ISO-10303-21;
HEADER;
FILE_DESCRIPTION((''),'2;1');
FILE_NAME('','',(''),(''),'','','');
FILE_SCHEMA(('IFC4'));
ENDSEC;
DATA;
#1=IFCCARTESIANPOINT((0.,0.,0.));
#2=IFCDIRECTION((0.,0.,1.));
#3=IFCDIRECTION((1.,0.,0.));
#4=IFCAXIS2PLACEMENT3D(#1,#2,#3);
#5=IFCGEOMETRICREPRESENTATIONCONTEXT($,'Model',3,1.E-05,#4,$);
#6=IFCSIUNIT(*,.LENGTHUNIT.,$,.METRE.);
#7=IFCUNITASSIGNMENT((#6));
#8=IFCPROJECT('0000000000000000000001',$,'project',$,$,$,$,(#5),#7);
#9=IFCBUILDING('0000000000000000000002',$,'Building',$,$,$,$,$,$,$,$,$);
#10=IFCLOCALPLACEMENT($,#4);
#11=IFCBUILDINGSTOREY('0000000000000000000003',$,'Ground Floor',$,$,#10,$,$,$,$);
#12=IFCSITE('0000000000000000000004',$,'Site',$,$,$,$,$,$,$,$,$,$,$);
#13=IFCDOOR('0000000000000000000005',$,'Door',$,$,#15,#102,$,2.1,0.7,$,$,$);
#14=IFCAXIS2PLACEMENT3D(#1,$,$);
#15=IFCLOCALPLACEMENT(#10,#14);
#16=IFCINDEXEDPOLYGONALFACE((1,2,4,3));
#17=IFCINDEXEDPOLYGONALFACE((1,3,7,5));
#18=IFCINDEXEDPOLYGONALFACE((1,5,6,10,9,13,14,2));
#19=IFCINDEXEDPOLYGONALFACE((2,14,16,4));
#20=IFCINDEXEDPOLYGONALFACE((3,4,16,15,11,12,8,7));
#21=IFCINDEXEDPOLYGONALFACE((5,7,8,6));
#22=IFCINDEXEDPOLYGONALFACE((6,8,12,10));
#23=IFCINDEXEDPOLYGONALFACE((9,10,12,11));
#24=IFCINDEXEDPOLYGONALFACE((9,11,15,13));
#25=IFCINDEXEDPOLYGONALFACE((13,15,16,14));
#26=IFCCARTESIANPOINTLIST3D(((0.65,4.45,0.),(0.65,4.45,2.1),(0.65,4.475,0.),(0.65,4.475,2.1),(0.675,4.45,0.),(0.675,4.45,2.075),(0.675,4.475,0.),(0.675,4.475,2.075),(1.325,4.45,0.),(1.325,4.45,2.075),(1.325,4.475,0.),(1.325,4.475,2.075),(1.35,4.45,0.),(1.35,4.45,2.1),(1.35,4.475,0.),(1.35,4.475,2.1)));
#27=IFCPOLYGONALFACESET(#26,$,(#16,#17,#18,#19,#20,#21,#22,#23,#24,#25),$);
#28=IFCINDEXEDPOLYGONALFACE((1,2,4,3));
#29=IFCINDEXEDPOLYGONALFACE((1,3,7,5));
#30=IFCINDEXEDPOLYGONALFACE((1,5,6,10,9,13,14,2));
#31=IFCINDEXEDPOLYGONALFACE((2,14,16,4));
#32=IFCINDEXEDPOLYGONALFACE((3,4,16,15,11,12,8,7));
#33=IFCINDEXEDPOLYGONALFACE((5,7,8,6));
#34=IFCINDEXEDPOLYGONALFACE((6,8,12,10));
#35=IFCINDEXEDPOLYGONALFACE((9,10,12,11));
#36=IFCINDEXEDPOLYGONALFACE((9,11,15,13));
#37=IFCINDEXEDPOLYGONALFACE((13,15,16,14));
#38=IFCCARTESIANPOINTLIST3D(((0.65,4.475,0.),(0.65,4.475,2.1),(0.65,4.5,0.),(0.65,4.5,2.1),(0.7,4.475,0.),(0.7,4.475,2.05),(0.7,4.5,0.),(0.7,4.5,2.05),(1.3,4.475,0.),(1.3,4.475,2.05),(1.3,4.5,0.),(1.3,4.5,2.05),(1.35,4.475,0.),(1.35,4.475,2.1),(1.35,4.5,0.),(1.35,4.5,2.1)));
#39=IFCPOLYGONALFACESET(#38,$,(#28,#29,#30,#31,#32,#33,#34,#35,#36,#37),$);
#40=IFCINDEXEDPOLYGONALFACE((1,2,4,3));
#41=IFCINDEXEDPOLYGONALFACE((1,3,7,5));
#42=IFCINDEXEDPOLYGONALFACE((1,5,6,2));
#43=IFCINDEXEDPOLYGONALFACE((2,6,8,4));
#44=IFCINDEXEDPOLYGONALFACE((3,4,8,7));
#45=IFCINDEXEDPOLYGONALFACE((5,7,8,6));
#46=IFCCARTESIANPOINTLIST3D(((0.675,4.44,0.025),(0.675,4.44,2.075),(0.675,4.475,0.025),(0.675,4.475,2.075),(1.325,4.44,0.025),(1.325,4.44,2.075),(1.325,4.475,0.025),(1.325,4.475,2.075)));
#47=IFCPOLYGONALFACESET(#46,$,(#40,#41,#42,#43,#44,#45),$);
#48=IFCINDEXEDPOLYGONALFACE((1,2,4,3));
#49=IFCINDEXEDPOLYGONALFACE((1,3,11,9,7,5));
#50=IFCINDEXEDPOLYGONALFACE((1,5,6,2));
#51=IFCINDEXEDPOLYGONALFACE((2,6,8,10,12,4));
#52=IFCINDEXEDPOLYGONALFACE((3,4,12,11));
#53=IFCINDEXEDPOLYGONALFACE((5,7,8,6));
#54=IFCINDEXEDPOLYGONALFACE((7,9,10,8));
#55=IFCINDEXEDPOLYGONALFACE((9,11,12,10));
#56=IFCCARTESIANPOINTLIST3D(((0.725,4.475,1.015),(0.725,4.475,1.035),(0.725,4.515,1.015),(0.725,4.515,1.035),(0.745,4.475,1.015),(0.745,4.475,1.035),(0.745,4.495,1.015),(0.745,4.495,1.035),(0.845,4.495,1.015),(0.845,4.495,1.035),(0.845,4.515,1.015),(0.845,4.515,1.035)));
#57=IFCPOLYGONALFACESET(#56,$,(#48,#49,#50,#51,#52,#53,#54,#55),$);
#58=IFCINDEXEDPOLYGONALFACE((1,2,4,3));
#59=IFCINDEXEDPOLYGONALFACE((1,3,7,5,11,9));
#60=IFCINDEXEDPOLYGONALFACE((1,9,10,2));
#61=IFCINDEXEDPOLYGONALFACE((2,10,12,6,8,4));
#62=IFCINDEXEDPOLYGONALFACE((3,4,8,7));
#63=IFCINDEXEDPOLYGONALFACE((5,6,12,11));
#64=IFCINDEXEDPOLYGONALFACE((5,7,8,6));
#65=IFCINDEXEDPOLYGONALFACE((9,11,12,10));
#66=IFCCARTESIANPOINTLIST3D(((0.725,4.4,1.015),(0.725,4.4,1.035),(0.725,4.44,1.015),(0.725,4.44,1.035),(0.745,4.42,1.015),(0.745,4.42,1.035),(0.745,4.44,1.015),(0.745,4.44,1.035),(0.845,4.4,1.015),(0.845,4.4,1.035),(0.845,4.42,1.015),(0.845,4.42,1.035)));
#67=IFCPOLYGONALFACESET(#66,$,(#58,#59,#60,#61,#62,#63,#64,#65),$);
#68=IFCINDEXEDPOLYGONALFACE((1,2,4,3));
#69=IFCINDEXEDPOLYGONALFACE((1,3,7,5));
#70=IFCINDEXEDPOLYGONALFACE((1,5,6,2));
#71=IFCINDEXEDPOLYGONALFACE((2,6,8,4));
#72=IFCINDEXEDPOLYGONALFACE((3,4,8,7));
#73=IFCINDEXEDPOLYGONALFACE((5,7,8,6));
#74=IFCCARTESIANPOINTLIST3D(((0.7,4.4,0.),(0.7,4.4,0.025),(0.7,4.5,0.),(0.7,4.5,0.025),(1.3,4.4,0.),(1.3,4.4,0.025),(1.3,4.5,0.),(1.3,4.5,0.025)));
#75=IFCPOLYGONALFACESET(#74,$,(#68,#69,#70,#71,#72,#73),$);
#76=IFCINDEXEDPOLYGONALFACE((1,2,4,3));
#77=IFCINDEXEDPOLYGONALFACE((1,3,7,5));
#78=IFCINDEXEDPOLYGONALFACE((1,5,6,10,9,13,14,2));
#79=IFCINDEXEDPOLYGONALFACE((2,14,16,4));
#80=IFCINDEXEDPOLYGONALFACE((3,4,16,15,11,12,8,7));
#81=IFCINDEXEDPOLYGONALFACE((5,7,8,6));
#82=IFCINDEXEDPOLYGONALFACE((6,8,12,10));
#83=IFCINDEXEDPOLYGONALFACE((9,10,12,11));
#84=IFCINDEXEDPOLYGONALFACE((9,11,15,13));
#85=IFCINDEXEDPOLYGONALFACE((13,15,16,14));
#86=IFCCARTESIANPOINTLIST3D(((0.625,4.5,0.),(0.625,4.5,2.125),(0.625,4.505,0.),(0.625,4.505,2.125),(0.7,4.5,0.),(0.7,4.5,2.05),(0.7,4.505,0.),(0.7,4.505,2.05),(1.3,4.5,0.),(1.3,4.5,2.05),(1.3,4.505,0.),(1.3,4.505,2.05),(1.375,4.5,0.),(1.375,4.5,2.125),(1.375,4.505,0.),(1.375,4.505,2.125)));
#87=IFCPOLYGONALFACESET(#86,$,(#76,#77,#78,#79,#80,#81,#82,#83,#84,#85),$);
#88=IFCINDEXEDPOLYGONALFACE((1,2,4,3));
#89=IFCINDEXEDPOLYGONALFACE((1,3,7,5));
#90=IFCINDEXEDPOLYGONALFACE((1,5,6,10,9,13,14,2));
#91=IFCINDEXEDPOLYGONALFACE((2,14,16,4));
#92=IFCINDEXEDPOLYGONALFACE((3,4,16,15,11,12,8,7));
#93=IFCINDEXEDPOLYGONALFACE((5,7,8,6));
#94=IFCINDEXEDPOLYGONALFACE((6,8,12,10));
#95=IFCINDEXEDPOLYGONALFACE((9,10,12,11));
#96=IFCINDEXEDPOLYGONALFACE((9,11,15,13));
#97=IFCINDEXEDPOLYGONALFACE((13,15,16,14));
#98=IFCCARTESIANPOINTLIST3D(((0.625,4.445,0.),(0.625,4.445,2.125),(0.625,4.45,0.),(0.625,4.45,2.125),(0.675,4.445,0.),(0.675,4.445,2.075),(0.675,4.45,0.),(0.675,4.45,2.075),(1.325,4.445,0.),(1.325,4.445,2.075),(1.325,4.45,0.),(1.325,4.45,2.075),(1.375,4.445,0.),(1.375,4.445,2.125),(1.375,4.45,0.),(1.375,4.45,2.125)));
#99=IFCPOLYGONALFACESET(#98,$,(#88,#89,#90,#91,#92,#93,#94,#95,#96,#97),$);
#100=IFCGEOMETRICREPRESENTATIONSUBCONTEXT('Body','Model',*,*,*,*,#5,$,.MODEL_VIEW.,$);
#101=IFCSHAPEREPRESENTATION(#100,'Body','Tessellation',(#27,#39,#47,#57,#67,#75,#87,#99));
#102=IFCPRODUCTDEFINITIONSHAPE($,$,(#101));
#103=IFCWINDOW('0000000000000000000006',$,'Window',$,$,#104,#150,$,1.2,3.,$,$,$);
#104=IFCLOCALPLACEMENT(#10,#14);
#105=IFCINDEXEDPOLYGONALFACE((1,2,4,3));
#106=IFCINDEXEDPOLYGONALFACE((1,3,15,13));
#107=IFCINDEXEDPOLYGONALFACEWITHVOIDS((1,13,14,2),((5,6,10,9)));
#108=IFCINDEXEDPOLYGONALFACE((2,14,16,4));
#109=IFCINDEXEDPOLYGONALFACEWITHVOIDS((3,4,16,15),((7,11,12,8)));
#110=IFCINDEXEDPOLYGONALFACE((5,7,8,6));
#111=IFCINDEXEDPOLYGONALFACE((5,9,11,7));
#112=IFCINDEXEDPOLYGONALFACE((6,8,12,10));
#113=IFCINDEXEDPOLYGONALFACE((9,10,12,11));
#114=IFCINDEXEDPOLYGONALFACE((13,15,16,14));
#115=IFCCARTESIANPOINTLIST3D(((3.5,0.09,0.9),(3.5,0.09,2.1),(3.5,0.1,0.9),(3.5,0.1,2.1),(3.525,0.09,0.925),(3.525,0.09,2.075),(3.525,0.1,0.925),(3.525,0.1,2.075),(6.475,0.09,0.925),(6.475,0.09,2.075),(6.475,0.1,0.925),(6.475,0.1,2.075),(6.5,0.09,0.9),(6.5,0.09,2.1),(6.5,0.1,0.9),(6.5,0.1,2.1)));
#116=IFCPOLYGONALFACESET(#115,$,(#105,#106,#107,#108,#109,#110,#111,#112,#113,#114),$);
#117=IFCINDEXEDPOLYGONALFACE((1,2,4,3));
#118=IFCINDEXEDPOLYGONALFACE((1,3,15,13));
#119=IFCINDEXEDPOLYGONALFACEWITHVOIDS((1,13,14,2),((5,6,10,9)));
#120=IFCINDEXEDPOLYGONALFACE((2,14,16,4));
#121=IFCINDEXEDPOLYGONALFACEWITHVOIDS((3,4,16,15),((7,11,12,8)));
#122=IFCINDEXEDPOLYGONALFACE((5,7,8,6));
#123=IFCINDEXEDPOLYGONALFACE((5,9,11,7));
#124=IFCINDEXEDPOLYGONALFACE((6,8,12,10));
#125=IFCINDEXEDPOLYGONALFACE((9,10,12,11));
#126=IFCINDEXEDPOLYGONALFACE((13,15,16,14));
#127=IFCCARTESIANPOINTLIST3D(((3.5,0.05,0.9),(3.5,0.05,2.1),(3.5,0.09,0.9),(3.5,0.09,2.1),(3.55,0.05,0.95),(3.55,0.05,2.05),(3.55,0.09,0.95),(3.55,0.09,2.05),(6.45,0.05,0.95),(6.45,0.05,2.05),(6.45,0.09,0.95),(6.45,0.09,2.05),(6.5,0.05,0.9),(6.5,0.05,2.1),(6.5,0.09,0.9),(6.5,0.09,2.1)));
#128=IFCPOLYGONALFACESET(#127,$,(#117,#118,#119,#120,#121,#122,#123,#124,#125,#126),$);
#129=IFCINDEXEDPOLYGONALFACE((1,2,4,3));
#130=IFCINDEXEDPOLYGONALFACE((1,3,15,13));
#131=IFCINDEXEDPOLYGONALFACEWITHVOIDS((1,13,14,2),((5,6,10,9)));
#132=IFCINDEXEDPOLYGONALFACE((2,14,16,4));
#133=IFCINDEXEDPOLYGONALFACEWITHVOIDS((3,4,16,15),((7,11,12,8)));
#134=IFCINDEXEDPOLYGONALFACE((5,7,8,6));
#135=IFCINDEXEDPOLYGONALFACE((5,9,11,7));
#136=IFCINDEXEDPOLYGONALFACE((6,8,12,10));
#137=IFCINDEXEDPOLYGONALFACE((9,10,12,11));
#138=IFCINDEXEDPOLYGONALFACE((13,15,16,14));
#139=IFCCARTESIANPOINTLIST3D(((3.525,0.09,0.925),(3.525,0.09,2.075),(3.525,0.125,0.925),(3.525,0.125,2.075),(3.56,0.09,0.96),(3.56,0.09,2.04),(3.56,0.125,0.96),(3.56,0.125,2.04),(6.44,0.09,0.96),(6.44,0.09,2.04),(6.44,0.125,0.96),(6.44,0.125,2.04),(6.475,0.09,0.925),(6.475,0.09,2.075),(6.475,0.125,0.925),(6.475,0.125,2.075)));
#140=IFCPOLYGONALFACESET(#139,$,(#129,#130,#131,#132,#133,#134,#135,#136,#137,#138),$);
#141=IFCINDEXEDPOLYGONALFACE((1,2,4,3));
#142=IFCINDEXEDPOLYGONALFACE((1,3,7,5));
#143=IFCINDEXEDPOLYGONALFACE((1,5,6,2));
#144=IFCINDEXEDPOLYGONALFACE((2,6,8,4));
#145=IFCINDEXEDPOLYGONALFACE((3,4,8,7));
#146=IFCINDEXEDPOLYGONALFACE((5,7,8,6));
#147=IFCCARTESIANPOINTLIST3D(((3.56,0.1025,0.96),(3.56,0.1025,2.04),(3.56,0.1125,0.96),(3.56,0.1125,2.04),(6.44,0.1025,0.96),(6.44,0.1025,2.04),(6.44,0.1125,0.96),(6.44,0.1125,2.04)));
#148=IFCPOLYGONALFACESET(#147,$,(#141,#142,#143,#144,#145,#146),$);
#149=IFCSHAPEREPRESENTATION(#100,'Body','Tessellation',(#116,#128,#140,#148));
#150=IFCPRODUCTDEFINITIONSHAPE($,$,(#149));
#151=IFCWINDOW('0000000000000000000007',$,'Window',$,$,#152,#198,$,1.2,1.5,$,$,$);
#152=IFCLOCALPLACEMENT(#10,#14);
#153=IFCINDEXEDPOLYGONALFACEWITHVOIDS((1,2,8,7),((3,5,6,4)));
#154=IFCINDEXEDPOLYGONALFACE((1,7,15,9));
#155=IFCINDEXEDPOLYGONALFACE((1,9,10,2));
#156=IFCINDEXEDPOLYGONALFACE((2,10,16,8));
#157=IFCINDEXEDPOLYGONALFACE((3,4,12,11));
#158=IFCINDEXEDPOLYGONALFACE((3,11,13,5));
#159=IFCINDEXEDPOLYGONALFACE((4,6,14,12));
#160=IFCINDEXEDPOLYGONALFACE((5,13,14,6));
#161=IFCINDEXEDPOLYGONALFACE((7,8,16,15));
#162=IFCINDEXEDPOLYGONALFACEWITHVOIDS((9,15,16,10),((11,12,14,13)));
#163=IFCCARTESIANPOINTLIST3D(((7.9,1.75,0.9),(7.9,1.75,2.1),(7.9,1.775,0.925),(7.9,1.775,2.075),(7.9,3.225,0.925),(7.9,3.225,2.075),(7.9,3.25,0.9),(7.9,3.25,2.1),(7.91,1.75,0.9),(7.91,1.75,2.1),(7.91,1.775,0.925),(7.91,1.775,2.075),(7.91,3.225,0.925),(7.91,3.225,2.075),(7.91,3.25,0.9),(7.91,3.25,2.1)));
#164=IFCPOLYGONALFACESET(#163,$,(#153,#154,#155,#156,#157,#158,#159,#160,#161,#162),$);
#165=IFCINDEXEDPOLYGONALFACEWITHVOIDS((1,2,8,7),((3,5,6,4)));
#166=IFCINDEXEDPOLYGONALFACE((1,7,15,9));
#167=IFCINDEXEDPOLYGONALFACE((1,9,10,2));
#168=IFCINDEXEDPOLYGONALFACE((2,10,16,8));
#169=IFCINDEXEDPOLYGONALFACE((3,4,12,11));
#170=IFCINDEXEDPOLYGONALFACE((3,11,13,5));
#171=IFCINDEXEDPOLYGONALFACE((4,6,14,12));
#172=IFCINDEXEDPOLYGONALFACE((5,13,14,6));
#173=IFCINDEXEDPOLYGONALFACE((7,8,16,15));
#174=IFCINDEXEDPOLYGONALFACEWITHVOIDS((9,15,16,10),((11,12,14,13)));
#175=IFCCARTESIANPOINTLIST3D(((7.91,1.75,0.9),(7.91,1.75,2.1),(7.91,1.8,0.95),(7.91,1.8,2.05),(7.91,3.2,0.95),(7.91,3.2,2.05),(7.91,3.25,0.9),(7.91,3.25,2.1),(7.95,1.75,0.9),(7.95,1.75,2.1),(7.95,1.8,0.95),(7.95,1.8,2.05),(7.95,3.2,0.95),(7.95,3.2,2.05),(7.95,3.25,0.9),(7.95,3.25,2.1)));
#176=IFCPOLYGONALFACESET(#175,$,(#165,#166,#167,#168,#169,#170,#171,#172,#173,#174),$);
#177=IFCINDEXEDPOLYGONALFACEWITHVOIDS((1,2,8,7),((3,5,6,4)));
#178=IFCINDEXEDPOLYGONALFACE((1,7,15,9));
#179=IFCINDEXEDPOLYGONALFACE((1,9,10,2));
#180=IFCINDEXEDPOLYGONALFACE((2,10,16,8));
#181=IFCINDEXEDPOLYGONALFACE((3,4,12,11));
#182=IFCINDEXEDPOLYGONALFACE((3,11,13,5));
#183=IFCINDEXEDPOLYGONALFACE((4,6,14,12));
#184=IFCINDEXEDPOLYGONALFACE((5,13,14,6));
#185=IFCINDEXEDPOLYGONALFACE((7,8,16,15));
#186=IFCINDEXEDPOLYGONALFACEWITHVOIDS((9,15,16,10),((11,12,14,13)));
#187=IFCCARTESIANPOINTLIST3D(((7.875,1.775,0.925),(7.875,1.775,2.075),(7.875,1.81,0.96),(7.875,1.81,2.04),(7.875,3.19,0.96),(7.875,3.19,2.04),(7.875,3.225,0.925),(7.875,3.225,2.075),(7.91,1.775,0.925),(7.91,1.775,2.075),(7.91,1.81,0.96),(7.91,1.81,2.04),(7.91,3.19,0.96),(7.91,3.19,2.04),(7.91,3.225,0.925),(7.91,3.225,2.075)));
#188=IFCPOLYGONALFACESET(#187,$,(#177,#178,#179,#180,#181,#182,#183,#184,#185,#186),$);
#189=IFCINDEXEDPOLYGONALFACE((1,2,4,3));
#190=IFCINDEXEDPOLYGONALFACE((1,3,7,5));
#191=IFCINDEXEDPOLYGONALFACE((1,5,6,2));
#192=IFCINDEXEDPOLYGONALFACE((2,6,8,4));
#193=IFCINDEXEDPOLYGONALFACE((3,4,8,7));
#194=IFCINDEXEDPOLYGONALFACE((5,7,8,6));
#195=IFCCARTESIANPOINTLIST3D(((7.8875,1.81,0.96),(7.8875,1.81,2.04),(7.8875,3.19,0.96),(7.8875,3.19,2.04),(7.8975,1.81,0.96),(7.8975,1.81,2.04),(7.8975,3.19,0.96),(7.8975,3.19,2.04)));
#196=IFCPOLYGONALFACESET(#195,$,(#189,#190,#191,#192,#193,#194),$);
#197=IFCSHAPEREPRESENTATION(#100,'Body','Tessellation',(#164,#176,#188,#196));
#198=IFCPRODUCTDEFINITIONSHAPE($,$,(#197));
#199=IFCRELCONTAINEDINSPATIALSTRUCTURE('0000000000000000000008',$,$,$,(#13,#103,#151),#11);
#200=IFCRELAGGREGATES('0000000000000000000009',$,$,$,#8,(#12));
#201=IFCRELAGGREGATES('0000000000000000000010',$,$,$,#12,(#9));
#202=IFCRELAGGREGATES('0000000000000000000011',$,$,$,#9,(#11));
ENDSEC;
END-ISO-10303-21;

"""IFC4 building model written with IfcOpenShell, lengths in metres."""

from ifc_helpers import new_model, si_unit, frame, origin_with_axes, place, context, subcontext, project, spatial, line, indexed_curve, outline, extrude, element, save


model = new_model("IFC4")

# Units and contexts
model_context = context("Model", 3, precision=1e-05, world=origin_with_axes())
body_context = subcontext(model_context, "Body", "Model", "MODEL_VIEW")
ifc_project = project(units=[si_unit("LENGTHUNIT", "METRE")], contexts=[model_context])

# Site, building, storey
site = spatial("IfcSite", under=ifc_project, Name="Site")
building = spatial("IfcBuilding", under=site, Name="Building")
storey_placement = place(None, origin_with_axes())
storey = spatial("IfcBuildingStorey", under=building, at=storey_placement, Name="Ground Floor")

# Door
door_1_placement = place(storey_placement, frame((1.35, 4.5, 0.0), z_axis=(0.0, 0.0, 1.0), x_axis=(-1.0, 0.0, 0.0)))
element("IfcDoor", 1, at=door_1_placement, inside=storey, Name="Door", OverallHeight=2.1, OverallWidth=0.7, context=body_context, shape_type="SweptSolid", body=[
    extrude(outline(indexed_curve([(0.0, 0.0), (0.0, 2.1), (0.7, 2.1), (0.7, 0.0), (0.675, 0.0), (0.675, 2.075), (0.025, 2.075), (0.025, 0.0)], segments=[line(1, 2, 3, 4, 5, 6, 7, 8, 1)])), frame((0.0, 0.025, 0.0), z_axis=(0.0, -1.0, 0.0), x_axis=(1.0, 0.0, 0.0)), (0.0, 0.0, -1.0), 0.025),
    extrude(outline(indexed_curve([(0.0, 0.0), (0.0, 2.1), (0.7, 2.1), (0.7, 0.0), (0.65, 0.0), (0.65, 2.05), (0.05, 2.05), (0.05, 0.0)], segments=[line(1, 2, 3, 4, 5, 6, 7, 8, 1)])), frame((0.0, 0.0, 0.0), z_axis=(0.0, -1.0, 0.0), x_axis=(1.0, 0.0, 0.0)), (0.0, 0.0, -1.0), 0.025),
    extrude(outline(indexed_curve([(0.0, 0.0), (0.65, 0.0), (0.65, 0.035), (0.0, 0.035)], segments=[line(1, 2, 3, 4, 1)])), frame((0.025, 0.025, 0.025), z_axis=(0.0, 0.0, 1.0), x_axis=(1.0, 0.0, 0.0)), (0.0, 0.0, 1.0), 2.05),
    extrude(outline(indexed_curve([(0.0, 0.0), (0.0, -0.04), (-0.12, -0.04), (-0.12, -0.02), (-0.02, -0.02), (-0.02, 0.0)], segments=[line(1, 2, 3, 4, 5, 6, 1)])), frame((0.625, 0.025, 1.015), z_axis=(0.0, 0.0, 1.0), x_axis=(1.0, 0.0, 0.0)), (0.0, 0.0, 1.0), 0.02),
    extrude(outline(indexed_curve([(0.0, 0.0), (0.0, 0.04), (-0.12, 0.04), (-0.12, 0.02), (-0.02, 0.02), (-0.02, 0.0)], segments=[line(1, 2, 3, 4, 5, 6, 1)])), frame((0.625, 0.06, 1.015), z_axis=(0.0, 0.0, 1.0), x_axis=(1.0, 0.0, 0.0)), (0.0, 0.0, 1.0), 0.02),
    extrude(outline(indexed_curve([(0.0, 0.0), (0.6, 0.0), (0.6, 0.1), (0.0, 0.1)], segments=[line(1, 2, 3, 4, 1)])), frame((0.05, 0.0, 0.0), z_axis=(0.0, 0.0, 1.0), x_axis=(1.0, 0.0, 0.0)), (0.0, 0.0, 1.0), 0.025),
    extrude(outline(indexed_curve([(0.0, 0.0), (0.0, 2.125), (0.75, 2.125), (0.75, 0.0), (0.675, 0.0), (0.675, 2.05), (0.075, 2.05), (0.075, 0.0)], segments=[line(1, 2, 3, 4, 5, 6, 7, 8, 1)])), frame((-0.025, -0.005, 0.0), z_axis=(0.0, -1.0, 0.0), x_axis=(1.0, 0.0, 0.0)), (0.0, 0.0, -1.0), 0.005),
    extrude(outline(indexed_curve([(0.0, 0.0), (0.0, 2.125), (0.75, 2.125), (0.75, 0.0), (0.7, 0.0), (0.7, 2.075), (0.05, 2.075), (0.05, 0.0)], segments=[line(1, 2, 3, 4, 5, 6, 7, 8, 1)])), frame((-0.025, 0.05, 0.0), z_axis=(0.0, -1.0, 0.0), x_axis=(1.0, 0.0, 0.0)), (0.0, 0.0, -1.0), 0.005),
])

# Windows
window_1_placement = place(storey_placement, frame((3.5, 0.0, 0.9), z_axis=(0.0, 0.0, 1.0), x_axis=(1.0, 0.0, 0.0)))
element("IfcWindow", 2, at=window_1_placement, inside=storey, Name="Window", OverallHeight=1.2, OverallWidth=3.0, context=body_context, shape_type="SweptSolid", body=[
    extrude(outline(indexed_curve([(0.0, 0.0), (3.0, 0.0), (3.0, 1.2), (0.0, 1.2)], segments=[line(1, 2, 3, 4, 1)]), holes=[indexed_curve([(0.025, 0.025), (2.975, 0.025), (2.975, 1.175), (0.025, 1.175)], segments=[line(1, 2, 3, 4, 1)])]), frame((0.0, 0.09, 0.0), z_axis=(0.0, -1.0, 0.0), x_axis=(1.0, 0.0, 0.0)), (0.0, 0.0, -1.0), 0.01),
    extrude(outline(indexed_curve([(0.0, 0.0), (3.0, 0.0), (3.0, 1.2), (0.0, 1.2)], segments=[line(1, 2, 3, 4, 1)]), holes=[indexed_curve([(0.05, 0.05), (2.95, 0.05), (2.95, 1.15), (0.05, 1.15)], segments=[line(1, 2, 3, 4, 1)])]), frame((0.0, 0.05, 0.0), z_axis=(0.0, -1.0, 0.0), x_axis=(1.0, 0.0, 0.0)), (0.0, 0.0, -1.0), 0.04),
    extrude(outline(indexed_curve([(0.0, 0.0), (2.95, 0.0), (2.95, 1.15), (0.0, 1.15)], segments=[line(1, 2, 3, 4, 1)]), holes=[indexed_curve([(0.035, 0.035), (2.915, 0.035), (2.915, 1.115), (0.035, 1.115)], segments=[line(1, 2, 3, 4, 1)])]), frame((0.025, 0.09, 0.025), z_axis=(0.0, -1.0, 0.0), x_axis=(1.0, 0.0, 0.0)), (0.0, 0.0, -1.0), 0.035),
    extrude(outline(indexed_curve([(0.035, 0.035), (2.915, 0.035), (2.915, 1.115), (0.035, 1.115)], segments=[line(1, 2, 3, 4, 1)])), frame((0.025, 0.1025, 0.025), z_axis=(0.0, -1.0, 0.0), x_axis=(1.0, 0.0, 0.0)), (0.0, 0.0, -1.0), 0.01),
])
window_2_placement = place(storey_placement, frame((8.0, 1.75, 0.9), z_axis=(0.0, 0.0, 1.0), x_axis=(0.0, 1.0, 0.0)))
element("IfcWindow", 3, at=window_2_placement, inside=storey, Name="Window", OverallHeight=1.2, OverallWidth=1.5, context=body_context, shape_type="SweptSolid", body=[
    extrude(outline(indexed_curve([(0.0, 0.0), (1.5, 0.0), (1.5, 1.2), (0.0, 1.2)], segments=[line(1, 2, 3, 4, 1)]), holes=[indexed_curve([(0.025, 0.025), (1.475, 0.025), (1.475, 1.175), (0.025, 1.175)], segments=[line(1, 2, 3, 4, 1)])]), frame((0.0, 0.09, 0.0), z_axis=(0.0, -1.0, 0.0), x_axis=(1.0, 0.0, 0.0)), (0.0, 0.0, -1.0), 0.01),
    extrude(outline(indexed_curve([(0.0, 0.0), (1.5, 0.0), (1.5, 1.2), (0.0, 1.2)], segments=[line(1, 2, 3, 4, 1)]), holes=[indexed_curve([(0.05, 0.05), (1.45, 0.05), (1.45, 1.15), (0.05, 1.15)], segments=[line(1, 2, 3, 4, 1)])]), frame((0.0, 0.05, 0.0), z_axis=(0.0, -1.0, 0.0), x_axis=(1.0, 0.0, 0.0)), (0.0, 0.0, -1.0), 0.04),
    extrude(outline(indexed_curve([(0.0, 0.0), (1.45, 0.0), (1.45, 1.15), (0.0, 1.15)], segments=[line(1, 2, 3, 4, 1)]), holes=[indexed_curve([(0.035, 0.035), (1.415, 0.035), (1.415, 1.115), (0.035, 1.115)], segments=[line(1, 2, 3, 4, 1)])]), frame((0.025, 0.09, 0.025), z_axis=(0.0, -1.0, 0.0), x_axis=(1.0, 0.0, 0.0)), (0.0, 0.0, -1.0), 0.035),
    extrude(outline(indexed_curve([(0.035, 0.035), (1.415, 0.035), (1.415, 1.115), (0.035, 1.115)], segments=[line(1, 2, 3, 4, 1)])), frame((0.025, 0.1025, 0.025), z_axis=(0.0, -1.0, 0.0), x_axis=(1.0, 0.0, 0.0)), (0.0, 0.0, -1.0), 0.01),
])

save(model, "model.ifc")
